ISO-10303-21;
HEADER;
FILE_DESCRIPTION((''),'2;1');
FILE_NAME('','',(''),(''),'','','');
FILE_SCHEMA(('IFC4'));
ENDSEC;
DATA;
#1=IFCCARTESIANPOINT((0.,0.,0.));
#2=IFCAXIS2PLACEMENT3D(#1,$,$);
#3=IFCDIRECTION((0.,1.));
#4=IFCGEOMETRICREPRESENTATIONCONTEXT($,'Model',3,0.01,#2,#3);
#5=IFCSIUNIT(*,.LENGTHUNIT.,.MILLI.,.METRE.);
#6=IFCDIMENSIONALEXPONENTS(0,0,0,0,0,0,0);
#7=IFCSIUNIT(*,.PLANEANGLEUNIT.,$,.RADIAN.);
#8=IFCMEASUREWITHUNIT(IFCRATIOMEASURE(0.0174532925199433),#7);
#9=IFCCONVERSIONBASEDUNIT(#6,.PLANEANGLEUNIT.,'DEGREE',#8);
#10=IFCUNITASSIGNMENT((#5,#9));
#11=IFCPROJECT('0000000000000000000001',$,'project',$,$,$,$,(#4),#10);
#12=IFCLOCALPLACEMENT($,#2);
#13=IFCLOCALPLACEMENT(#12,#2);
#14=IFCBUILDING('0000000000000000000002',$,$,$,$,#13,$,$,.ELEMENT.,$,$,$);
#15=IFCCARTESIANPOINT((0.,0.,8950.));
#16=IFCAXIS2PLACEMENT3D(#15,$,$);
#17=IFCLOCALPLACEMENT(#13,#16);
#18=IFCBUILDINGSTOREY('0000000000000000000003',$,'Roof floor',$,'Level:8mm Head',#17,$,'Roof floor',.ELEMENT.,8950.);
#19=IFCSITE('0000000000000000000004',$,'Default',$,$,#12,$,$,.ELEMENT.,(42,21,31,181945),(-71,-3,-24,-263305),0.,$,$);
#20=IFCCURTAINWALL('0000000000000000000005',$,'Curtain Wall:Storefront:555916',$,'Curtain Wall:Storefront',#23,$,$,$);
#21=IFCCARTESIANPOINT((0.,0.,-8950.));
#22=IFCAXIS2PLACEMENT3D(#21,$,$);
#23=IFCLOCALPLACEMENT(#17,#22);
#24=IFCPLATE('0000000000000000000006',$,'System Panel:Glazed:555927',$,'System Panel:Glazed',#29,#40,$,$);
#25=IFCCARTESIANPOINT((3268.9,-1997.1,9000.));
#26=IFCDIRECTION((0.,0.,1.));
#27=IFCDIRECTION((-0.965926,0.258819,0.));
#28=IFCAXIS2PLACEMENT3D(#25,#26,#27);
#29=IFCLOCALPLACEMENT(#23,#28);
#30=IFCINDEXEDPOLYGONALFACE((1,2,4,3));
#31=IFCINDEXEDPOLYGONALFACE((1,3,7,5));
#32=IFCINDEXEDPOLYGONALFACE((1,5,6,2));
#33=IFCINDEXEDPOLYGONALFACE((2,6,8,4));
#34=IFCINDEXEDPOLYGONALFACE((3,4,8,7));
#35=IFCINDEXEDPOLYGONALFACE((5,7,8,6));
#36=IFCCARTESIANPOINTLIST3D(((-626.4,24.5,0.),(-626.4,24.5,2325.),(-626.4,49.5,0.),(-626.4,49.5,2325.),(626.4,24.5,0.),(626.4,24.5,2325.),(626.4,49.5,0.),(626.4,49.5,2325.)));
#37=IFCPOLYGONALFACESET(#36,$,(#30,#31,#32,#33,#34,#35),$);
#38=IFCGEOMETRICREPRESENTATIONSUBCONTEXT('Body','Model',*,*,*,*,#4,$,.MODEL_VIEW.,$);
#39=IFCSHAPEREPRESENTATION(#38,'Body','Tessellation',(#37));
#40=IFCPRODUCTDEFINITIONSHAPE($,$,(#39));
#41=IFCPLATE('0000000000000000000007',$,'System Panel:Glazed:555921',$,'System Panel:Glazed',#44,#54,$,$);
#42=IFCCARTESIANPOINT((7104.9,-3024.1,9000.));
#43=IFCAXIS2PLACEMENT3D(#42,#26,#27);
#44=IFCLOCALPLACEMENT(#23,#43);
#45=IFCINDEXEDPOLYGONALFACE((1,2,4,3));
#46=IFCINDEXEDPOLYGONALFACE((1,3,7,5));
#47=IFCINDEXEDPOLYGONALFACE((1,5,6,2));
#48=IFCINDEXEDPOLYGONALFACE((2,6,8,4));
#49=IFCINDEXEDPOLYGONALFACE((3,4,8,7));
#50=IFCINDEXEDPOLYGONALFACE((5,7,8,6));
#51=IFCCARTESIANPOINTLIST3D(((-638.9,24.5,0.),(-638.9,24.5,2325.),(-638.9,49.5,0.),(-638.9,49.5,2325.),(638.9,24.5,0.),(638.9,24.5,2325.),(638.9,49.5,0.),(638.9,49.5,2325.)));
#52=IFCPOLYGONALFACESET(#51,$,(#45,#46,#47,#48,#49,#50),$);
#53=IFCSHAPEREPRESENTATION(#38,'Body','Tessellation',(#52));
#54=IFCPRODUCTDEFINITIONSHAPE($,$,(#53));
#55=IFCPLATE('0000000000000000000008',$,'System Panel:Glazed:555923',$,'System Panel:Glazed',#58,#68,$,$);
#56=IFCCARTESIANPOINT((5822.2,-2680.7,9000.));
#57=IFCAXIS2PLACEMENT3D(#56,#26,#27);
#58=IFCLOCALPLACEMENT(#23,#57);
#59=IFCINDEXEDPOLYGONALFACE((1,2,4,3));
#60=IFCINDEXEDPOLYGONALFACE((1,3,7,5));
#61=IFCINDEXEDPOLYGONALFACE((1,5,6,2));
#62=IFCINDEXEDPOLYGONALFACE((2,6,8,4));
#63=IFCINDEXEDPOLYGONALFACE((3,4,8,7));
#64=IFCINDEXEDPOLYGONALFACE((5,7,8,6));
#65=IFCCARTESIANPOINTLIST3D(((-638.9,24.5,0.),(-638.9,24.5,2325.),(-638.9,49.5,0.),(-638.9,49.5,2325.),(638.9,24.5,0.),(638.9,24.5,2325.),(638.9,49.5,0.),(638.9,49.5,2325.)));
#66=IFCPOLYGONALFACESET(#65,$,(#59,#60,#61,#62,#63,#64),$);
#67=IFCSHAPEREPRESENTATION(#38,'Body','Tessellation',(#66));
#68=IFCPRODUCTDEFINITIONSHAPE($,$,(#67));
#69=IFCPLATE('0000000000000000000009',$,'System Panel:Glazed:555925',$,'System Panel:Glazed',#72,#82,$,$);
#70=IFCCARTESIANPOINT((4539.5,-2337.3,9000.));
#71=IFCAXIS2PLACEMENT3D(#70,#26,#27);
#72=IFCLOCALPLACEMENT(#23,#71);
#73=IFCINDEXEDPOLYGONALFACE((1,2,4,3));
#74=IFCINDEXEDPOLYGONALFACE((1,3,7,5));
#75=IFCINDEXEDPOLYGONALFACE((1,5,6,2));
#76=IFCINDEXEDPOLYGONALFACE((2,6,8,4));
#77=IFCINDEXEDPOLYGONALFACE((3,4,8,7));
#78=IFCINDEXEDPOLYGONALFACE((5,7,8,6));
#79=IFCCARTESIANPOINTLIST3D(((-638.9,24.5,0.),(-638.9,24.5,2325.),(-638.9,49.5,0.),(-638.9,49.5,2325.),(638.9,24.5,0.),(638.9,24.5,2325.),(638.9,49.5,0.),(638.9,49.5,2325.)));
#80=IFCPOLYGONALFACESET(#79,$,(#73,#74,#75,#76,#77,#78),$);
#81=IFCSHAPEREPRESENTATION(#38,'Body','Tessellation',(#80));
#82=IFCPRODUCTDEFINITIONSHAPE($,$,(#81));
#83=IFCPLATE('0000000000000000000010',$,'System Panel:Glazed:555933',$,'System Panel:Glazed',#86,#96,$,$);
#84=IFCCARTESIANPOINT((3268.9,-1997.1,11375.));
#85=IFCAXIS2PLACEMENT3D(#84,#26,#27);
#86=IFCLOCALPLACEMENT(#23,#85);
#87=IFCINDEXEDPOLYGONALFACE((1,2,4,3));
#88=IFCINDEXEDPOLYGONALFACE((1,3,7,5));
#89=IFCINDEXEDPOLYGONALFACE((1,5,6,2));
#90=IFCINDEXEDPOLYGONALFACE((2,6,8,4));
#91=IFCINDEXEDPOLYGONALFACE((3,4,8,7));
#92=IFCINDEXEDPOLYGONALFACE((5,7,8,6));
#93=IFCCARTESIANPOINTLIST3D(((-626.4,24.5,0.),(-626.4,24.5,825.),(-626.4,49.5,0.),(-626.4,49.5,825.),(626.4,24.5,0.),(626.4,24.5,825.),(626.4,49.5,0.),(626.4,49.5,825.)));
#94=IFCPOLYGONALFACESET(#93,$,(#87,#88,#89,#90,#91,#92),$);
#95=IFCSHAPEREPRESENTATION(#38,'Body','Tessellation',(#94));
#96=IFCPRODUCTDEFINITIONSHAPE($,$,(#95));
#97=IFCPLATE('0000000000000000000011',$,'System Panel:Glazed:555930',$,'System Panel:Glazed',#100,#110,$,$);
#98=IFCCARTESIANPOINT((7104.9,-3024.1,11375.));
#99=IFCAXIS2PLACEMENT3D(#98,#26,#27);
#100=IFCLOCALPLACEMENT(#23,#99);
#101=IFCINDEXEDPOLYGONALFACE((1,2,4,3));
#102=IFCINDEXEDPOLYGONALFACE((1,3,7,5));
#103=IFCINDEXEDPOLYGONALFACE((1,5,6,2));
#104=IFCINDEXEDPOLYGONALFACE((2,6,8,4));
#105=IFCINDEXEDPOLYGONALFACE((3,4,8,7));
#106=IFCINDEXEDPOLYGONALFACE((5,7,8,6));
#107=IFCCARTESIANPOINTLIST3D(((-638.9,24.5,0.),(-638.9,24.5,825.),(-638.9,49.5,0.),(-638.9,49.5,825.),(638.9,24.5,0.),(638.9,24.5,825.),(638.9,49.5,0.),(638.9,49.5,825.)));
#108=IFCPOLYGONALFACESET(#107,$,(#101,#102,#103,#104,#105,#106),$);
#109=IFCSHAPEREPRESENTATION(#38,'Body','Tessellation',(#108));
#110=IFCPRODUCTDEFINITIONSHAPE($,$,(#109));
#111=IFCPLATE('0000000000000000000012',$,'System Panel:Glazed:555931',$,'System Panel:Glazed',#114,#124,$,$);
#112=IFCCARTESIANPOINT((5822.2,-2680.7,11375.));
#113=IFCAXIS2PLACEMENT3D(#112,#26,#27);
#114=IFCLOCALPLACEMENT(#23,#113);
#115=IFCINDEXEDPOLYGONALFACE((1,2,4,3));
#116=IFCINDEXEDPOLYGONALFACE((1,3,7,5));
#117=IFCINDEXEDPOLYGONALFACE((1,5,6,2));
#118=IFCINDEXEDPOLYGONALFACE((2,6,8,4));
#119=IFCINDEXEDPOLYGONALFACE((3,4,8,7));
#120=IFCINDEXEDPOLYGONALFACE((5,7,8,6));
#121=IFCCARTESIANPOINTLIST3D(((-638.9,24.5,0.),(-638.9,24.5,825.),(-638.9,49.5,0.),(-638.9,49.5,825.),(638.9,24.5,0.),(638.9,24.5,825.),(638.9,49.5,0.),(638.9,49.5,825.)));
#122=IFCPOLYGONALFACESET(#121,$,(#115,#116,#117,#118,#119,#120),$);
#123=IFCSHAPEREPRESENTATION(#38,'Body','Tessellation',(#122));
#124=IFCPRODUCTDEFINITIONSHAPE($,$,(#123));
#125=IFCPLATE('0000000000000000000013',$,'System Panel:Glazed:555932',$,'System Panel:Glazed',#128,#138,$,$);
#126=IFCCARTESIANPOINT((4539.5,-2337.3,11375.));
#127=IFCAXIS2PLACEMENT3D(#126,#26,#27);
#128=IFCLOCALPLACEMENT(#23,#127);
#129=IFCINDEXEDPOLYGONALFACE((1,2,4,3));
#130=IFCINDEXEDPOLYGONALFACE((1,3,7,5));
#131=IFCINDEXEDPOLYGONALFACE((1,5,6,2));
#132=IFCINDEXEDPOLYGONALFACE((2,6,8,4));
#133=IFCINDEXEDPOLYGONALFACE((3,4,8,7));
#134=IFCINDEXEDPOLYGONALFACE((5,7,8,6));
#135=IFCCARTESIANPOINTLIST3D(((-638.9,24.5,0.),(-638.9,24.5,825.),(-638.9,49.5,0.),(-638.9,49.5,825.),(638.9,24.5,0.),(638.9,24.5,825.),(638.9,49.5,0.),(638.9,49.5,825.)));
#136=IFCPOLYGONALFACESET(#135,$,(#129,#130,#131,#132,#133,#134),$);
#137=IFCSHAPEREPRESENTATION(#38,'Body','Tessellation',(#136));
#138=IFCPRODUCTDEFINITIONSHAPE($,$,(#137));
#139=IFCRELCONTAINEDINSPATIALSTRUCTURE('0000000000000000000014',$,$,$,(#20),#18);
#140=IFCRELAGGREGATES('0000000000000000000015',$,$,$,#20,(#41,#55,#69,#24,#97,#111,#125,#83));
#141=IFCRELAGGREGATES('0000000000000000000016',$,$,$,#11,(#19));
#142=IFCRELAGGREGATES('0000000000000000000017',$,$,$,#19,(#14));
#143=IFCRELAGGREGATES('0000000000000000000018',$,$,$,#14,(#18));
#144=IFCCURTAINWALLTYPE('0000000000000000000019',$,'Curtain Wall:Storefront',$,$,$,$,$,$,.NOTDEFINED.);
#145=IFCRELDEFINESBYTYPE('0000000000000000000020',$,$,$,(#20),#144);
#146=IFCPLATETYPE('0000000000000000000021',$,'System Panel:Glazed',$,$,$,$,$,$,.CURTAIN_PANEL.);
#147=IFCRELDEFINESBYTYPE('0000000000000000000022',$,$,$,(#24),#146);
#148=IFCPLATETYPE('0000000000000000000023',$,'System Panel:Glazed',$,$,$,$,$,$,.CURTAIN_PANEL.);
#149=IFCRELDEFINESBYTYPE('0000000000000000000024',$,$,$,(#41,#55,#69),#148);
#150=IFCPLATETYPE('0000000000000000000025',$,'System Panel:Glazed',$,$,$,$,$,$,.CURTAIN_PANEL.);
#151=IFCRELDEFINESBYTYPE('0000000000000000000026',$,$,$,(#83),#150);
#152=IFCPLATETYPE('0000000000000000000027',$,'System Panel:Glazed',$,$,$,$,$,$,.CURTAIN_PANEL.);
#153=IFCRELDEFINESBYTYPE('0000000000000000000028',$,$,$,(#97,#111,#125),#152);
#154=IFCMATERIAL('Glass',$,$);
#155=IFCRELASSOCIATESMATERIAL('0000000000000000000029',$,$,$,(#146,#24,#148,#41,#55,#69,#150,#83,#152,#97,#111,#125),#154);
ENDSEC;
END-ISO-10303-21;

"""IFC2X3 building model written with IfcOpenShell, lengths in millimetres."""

from ifc_helpers import new_model, entity, si_unit, converted_unit, direction, frame, origin, origin_2d_with_axis, place, context, subcontext, project, spatial, rectangle, extrude, source, transform, mapped, material, type_object, type_shapes, element, aggregate, save


model = new_model("IFC2X3")

# Units and contexts
model_context = context("Model", 3, precision=0.01, world=origin(), true_north=direction((0.0, 1.0)))
body_context = subcontext(model_context, "Body", "Model", "MODEL_VIEW")
ifc_project = project(units=[si_unit("LENGTHUNIT", "METRE", prefix="MILLI"), converted_unit("PLANEANGLEUNIT", "DEGREE", entity("IfcRatioMeasure", 0.0174532925199433), si_unit("PLANEANGLEUNIT", "RADIAN"), dimensions=[0, 0, 0, 0, 0, 0, 0])], contexts=[model_context])

# Site, building, storey
site_placement = place(None, origin())
site = spatial("IfcSite", under=ifc_project, at=site_placement, Name="Default", CompositionType="ELEMENT", RefLatitude=(42, 21, 31, 181945), RefLongitude=(-71, -3, -24, -263305), RefElevation=0.0)
building_placement = place(site_placement, origin())
building = spatial("IfcBuilding", under=site, at=building_placement, CompositionType="ELEMENT")
storey_placement = place(building_placement, frame((0.0, 0.0, 8950.0)))
storey = spatial("IfcBuildingStorey", under=building, at=storey_placement, Name="Roof floor", ObjectType="Level:8mm Head", LongName="Roof floor", CompositionType="ELEMENT", Elevation=8950.0)

# Curtain wall, plates
curtain_wall_type = type_object("IfcCurtainWallType", Name="Curtain Wall:Storefront", PredefinedType="NOTDEFINED")
curtain_wall_placement = place(storey_placement, frame((0.0, 0.0, -8950.0)))
curtain_wall = element("IfcCurtainWall", 1, at=curtain_wall_placement, inside=storey, type_object=curtain_wall_type, Name="Curtain Wall:Storefront:555916", ObjectType="Curtain Wall:Storefront")
ifc_material_1 = material(Name="Glass")
plate_type_1 = type_object("IfcPlateType", Name="System Panel:Glazed", PredefinedType="CURTAIN_PANEL", material=ifc_material_1)
shared_shape_1 = source(origin(), body_context, "Body", "SweptSolid", [
    extrude(rectangle(XDim=25.0, YDim=1252.9, at=origin_2d_with_axis()), frame((0.0, 37.0, 0.0), z_axis=(0.0, 0.0, 1.0), x_axis=(0.0, 1.0, 0.0)), (0.0, 0.0, 1.0), 2325.0),
])
type_shapes(plate_type_1, [shared_shape_1])
plate_1_placement = place(curtain_wall_placement, frame((3268.9, -1997.1, 9000.0), z_axis=(0.0, 0.0, 1.0), x_axis=(-0.965926, 0.258819, 0.0)))
plate_1 = element("IfcPlate", 2, at=plate_1_placement, type_object=plate_type_1, material=ifc_material_1, Name="System Panel:Glazed:555927", ObjectType="System Panel:Glazed", context=body_context, shape_type="MappedRepresentation", body=[
    mapped(shared_shape_1, transform((0.0, 0.0, 0.0), scale=1.0)),
])
plate_type_2 = type_object("IfcPlateType", Name="System Panel:Glazed", PredefinedType="CURTAIN_PANEL", material=ifc_material_1)
shared_shape_2 = source(origin(), body_context, "Body", "SweptSolid", [
    extrude(rectangle(XDim=25.0, YDim=1277.9, at=origin_2d_with_axis()), frame((0.0, 37.0, 0.0), z_axis=(0.0, 0.0, 1.0), x_axis=(0.0, 1.0, 0.0)), (0.0, 0.0, 1.0), 2325.0),
])
type_shapes(plate_type_2, [shared_shape_2])
plate_2_placement = place(curtain_wall_placement, frame((7104.9, -3024.1, 9000.0), z_axis=(0.0, 0.0, 1.0), x_axis=(-0.965926, 0.258819, 0.0)))
plate_2 = element("IfcPlate", 3, at=plate_2_placement, type_object=plate_type_2, material=ifc_material_1, Name="System Panel:Glazed:555921", ObjectType="System Panel:Glazed", context=body_context, shape_type="MappedRepresentation", body=[
    mapped(shared_shape_2, transform((0.0, 0.0, 0.0), scale=1.0)),
])
plate_3_placement = place(curtain_wall_placement, frame((5822.2, -2680.7, 9000.0), z_axis=(0.0, 0.0, 1.0), x_axis=(-0.965926, 0.258819, 0.0)))
plate_3 = element("IfcPlate", 4, at=plate_3_placement, type_object=plate_type_2, material=ifc_material_1, Name="System Panel:Glazed:555923", ObjectType="System Panel:Glazed", context=body_context, shape_type="MappedRepresentation", body=[
    mapped(shared_shape_2, transform((0.0, 0.0, 0.0), scale=1.0)),
])
plate_4_placement = place(curtain_wall_placement, frame((4539.5, -2337.3, 9000.0), z_axis=(0.0, 0.0, 1.0), x_axis=(-0.965926, 0.258819, 0.0)))
plate_4 = element("IfcPlate", 5, at=plate_4_placement, type_object=plate_type_2, material=ifc_material_1, Name="System Panel:Glazed:555925", ObjectType="System Panel:Glazed", context=body_context, shape_type="MappedRepresentation", body=[
    mapped(shared_shape_2, transform((0.0, 0.0, 0.0), scale=1.0)),
])
plate_type_3 = type_object("IfcPlateType", Name="System Panel:Glazed", PredefinedType="CURTAIN_PANEL", material=ifc_material_1)
shared_shape_3 = source(origin(), body_context, "Body", "SweptSolid", [
    extrude(rectangle(XDim=25.0, YDim=1252.9, at=origin_2d_with_axis()), frame((0.0, 37.0, 0.0), z_axis=(0.0, 0.0, 1.0), x_axis=(0.0, 1.0, 0.0)), (0.0, 0.0, 1.0), 825.0),
])
type_shapes(plate_type_3, [shared_shape_3])
plate_5_placement = place(curtain_wall_placement, frame((3268.9, -1997.1, 11375.0), z_axis=(0.0, 0.0, 1.0), x_axis=(-0.965926, 0.258819, 0.0)))
plate_5 = element("IfcPlate", 6, at=plate_5_placement, type_object=plate_type_3, material=ifc_material_1, Name="System Panel:Glazed:555933", ObjectType="System Panel:Glazed", context=body_context, shape_type="MappedRepresentation", body=[
    mapped(shared_shape_3, transform((0.0, 0.0, 0.0), scale=1.0)),
])
plate_type_4 = type_object("IfcPlateType", Name="System Panel:Glazed", PredefinedType="CURTAIN_PANEL", material=ifc_material_1)
shared_shape_4 = source(origin(), body_context, "Body", "SweptSolid", [
    extrude(rectangle(XDim=25.0, YDim=1277.9, at=origin_2d_with_axis()), frame((0.0, 37.0, 0.0), z_axis=(0.0, 0.0, 1.0), x_axis=(0.0, 1.0, 0.0)), (0.0, 0.0, 1.0), 825.0),
])
type_shapes(plate_type_4, [shared_shape_4])
plate_6_placement = place(curtain_wall_placement, frame((7104.9, -3024.1, 11375.0), z_axis=(0.0, 0.0, 1.0), x_axis=(-0.965926, 0.258819, 0.0)))
plate_6 = element("IfcPlate", 7, at=plate_6_placement, type_object=plate_type_4, material=ifc_material_1, Name="System Panel:Glazed:555930", ObjectType="System Panel:Glazed", context=body_context, shape_type="MappedRepresentation", body=[
    mapped(shared_shape_4, transform((0.0, 0.0, 0.0), scale=1.0)),
])
plate_7_placement = place(curtain_wall_placement, frame((5822.2, -2680.7, 11375.0), z_axis=(0.0, 0.0, 1.0), x_axis=(-0.965926, 0.258819, 0.0)))
plate_7 = element("IfcPlate", 8, at=plate_7_placement, type_object=plate_type_4, material=ifc_material_1, Name="System Panel:Glazed:555931", ObjectType="System Panel:Glazed", context=body_context, shape_type="MappedRepresentation", body=[
    mapped(shared_shape_4, transform((0.0, 0.0, 0.0), scale=1.0)),
])
plate_8_placement = place(curtain_wall_placement, frame((4539.5, -2337.3, 11375.0), z_axis=(0.0, 0.0, 1.0), x_axis=(-0.965926, 0.258819, 0.0)))
plate_8 = element("IfcPlate", 9, at=plate_8_placement, type_object=plate_type_4, material=ifc_material_1, Name="System Panel:Glazed:555932", ObjectType="System Panel:Glazed", context=body_context, shape_type="MappedRepresentation", body=[
    mapped(shared_shape_4, transform((0.0, 0.0, 0.0), scale=1.0)),
])
aggregate(curtain_wall, [plate_2, plate_3, plate_4, plate_1, plate_6, plate_7, plate_8, plate_5])

save(model, "model.ifc")
